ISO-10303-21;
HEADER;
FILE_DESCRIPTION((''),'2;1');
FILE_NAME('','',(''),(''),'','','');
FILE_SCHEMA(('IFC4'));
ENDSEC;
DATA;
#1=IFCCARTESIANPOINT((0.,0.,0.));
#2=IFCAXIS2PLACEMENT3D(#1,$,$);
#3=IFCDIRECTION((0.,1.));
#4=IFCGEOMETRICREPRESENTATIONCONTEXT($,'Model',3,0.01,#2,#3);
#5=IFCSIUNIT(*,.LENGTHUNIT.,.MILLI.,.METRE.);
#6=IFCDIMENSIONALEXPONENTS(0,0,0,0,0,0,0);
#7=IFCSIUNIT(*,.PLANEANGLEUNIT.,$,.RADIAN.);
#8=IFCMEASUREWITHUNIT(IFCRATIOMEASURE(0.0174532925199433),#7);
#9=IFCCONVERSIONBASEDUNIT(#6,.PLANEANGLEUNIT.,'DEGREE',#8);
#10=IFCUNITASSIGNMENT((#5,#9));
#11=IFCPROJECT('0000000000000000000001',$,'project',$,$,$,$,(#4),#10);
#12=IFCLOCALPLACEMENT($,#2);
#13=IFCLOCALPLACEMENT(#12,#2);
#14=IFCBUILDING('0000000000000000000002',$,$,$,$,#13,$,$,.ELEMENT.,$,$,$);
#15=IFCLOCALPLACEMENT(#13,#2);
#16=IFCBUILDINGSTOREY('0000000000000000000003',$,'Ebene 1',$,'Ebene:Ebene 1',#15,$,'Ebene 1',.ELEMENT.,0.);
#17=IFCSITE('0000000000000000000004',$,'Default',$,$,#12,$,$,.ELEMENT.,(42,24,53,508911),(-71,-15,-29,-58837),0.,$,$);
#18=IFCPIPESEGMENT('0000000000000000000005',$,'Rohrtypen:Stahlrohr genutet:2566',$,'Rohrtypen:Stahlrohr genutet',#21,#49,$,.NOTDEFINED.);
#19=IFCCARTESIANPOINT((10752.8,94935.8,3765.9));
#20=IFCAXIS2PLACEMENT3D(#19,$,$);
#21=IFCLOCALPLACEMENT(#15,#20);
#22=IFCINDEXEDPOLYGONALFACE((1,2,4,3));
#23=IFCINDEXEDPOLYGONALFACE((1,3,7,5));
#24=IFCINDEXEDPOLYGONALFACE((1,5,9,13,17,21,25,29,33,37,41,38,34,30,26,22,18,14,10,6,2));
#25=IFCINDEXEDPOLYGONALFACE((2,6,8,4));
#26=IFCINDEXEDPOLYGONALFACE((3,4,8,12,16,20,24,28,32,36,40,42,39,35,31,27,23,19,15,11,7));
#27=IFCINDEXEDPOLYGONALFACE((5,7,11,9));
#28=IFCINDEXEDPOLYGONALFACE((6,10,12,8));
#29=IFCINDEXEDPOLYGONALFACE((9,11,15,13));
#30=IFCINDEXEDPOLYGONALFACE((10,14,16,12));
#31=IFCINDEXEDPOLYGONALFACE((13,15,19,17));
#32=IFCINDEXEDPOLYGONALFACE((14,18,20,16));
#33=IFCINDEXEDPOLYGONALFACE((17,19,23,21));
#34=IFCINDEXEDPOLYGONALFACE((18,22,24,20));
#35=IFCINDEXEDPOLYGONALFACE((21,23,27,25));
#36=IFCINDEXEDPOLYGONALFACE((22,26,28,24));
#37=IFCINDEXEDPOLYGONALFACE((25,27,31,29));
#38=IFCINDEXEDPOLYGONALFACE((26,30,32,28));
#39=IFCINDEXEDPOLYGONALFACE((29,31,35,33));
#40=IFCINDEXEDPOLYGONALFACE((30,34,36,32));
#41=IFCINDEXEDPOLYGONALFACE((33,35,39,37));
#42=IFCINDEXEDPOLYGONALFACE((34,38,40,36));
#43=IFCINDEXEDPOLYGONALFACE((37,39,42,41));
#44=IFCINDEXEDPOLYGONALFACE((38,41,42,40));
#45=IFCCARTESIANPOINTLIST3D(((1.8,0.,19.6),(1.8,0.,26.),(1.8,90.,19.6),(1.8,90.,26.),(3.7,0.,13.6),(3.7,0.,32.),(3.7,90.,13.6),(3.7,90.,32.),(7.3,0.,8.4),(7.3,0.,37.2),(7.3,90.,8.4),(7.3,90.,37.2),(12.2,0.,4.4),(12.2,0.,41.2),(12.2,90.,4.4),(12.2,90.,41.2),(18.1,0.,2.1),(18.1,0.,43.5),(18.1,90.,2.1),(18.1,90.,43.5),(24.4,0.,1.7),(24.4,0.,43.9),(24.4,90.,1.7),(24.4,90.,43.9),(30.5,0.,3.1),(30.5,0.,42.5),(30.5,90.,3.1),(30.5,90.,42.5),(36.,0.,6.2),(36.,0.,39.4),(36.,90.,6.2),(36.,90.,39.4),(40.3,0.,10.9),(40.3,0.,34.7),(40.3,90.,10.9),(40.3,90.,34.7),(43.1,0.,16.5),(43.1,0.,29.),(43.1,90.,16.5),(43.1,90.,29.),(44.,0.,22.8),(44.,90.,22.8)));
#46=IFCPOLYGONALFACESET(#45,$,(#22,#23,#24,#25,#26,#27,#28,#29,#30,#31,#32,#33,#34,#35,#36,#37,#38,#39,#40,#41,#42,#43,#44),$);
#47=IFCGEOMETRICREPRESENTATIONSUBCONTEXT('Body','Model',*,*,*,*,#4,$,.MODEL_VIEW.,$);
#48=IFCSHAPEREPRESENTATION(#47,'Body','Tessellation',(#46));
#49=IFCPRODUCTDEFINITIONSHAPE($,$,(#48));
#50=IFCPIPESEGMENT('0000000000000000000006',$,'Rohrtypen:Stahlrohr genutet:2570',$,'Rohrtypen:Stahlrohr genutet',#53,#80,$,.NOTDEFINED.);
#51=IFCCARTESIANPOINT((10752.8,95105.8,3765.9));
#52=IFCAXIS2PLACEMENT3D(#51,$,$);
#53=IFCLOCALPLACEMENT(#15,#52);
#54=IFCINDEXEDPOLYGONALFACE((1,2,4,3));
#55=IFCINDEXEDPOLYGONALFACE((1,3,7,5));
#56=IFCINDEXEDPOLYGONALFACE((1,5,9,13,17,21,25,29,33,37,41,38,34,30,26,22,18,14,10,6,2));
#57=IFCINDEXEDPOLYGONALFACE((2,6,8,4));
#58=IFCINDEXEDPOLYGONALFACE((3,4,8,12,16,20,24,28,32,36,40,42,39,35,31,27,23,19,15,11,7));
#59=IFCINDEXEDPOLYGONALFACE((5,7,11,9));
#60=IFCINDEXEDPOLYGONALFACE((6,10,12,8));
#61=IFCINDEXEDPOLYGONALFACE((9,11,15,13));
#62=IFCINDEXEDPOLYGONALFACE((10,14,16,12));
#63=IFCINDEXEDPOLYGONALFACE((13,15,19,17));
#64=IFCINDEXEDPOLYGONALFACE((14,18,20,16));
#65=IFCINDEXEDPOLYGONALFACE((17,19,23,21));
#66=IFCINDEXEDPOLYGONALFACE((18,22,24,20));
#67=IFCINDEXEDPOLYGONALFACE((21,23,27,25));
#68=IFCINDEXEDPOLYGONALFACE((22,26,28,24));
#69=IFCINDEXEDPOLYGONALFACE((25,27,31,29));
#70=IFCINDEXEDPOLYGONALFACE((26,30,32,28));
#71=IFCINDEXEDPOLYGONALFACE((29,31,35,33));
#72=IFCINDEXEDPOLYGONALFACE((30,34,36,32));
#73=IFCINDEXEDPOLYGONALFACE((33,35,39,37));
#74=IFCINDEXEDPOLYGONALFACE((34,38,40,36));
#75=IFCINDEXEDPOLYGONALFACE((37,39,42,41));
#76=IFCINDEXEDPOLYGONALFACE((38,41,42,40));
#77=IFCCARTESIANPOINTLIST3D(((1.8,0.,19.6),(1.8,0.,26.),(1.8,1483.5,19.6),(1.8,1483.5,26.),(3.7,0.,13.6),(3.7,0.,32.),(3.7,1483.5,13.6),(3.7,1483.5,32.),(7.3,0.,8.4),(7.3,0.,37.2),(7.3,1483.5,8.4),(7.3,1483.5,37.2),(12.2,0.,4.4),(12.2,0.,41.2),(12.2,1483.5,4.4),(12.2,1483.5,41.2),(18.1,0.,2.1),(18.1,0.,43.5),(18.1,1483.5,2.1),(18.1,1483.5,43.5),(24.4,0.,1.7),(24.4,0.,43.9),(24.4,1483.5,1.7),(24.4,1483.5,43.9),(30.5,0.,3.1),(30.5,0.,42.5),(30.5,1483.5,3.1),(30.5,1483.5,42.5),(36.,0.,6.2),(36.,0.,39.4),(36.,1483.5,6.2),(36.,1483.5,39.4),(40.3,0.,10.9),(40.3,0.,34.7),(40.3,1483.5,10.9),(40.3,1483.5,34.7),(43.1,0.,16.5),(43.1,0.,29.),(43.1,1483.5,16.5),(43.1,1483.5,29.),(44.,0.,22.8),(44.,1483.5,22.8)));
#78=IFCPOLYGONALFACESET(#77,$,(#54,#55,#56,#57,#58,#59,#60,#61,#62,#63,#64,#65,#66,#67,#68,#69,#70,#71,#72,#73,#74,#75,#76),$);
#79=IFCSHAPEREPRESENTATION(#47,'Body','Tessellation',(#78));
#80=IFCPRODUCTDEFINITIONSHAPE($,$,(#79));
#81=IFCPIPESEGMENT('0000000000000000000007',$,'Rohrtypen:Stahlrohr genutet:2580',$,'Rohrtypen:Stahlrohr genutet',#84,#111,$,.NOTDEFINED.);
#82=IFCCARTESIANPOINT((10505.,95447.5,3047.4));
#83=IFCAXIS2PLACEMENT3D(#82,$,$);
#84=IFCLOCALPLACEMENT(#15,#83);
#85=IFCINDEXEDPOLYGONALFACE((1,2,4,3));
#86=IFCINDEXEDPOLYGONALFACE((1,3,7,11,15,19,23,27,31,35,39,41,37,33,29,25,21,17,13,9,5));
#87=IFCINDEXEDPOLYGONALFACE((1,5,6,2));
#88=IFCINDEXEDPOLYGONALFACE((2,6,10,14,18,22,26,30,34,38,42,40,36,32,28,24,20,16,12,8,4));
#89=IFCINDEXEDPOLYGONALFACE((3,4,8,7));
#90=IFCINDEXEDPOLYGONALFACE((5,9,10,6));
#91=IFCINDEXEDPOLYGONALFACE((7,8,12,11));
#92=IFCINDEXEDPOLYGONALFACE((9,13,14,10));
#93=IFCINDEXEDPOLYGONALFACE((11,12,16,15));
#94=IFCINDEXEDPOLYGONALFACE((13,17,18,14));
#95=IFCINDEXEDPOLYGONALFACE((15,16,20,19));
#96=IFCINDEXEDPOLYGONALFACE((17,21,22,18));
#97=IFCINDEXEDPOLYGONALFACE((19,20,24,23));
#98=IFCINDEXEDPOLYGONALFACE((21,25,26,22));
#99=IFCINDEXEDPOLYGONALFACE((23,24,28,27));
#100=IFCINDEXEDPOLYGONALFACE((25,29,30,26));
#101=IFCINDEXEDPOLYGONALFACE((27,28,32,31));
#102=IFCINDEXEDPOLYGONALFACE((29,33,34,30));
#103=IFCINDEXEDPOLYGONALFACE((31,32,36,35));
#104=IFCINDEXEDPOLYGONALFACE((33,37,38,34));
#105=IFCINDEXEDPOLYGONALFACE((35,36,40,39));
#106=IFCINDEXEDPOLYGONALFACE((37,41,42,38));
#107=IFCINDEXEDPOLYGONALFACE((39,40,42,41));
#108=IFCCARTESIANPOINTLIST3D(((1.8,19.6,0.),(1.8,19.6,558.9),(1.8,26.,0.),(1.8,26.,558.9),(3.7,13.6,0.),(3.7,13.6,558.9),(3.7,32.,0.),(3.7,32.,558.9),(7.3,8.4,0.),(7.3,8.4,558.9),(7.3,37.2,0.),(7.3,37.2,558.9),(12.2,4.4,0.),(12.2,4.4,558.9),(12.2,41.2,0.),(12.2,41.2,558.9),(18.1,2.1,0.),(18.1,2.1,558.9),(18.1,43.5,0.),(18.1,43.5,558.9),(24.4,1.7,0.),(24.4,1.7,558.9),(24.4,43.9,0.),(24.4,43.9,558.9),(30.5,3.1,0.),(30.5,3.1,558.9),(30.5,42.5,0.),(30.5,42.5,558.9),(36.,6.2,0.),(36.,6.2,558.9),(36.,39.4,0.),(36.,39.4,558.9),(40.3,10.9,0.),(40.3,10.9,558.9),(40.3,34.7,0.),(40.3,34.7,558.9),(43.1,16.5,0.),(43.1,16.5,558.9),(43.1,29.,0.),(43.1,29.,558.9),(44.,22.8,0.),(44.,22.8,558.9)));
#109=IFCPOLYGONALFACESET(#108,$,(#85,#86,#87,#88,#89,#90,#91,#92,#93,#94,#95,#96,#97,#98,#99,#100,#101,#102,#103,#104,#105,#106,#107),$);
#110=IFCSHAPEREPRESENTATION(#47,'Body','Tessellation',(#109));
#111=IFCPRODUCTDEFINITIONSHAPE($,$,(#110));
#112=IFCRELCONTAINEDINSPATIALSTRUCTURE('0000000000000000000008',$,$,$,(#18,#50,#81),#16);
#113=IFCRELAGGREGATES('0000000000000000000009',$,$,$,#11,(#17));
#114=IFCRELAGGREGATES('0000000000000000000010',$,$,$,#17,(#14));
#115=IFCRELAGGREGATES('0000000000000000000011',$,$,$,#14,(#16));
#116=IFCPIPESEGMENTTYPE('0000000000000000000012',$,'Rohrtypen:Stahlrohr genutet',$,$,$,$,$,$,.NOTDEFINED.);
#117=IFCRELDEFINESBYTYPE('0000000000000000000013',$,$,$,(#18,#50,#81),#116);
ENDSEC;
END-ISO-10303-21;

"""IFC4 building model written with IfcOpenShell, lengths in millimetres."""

from ifc_helpers import new_model, entity, si_unit, converted_unit, direction, frame, frame_2d, origin, origin_2d_with_axis, place, context, subcontext, project, spatial, circle, extrude, type_object, element, save


model = new_model("IFC4")

# Units and contexts
model_context = context("Model", 3, precision=0.01, world=origin(), true_north=direction((0.0, 1.0)))
body_context = subcontext(model_context, "Body", "Model", "MODEL_VIEW")
ifc_project = project(units=[si_unit("LENGTHUNIT", "METRE", prefix="MILLI"), converted_unit("PLANEANGLEUNIT", "DEGREE", entity("IfcRatioMeasure", 0.0174532925199433), si_unit("PLANEANGLEUNIT", "RADIAN"), dimensions=[0, 0, 0, 0, 0, 0, 0])], contexts=[model_context])

# Site, building, storey
site_placement = place(None, origin())
site = spatial("IfcSite", under=ifc_project, at=site_placement, Name="Default", CompositionType="ELEMENT", RefLatitude=(42, 24, 53, 508911), RefLongitude=(-71, -15, -29, -58837), RefElevation=0.0)
building_placement = place(site_placement, origin())
building = spatial("IfcBuilding", under=site, at=building_placement, CompositionType="ELEMENT")
storey_placement = place(building_placement, origin())
storey = spatial("IfcBuildingStorey", under=building, at=storey_placement, Name="Ebene 1", ObjectType="Ebene:Ebene 1", LongName="Ebene 1", CompositionType="ELEMENT", Elevation=0.0)

# Pipe segments
pipe_segment_type = type_object("IfcPipeSegmentType", Name="Rohrtypen:Stahlrohr genutet", PredefinedType="NOTDEFINED")
pipe_segment_1_placement = place(storey_placement, frame((10752.8, 94935.8, 3765.9)))
element("IfcPipeSegment", 1, at=pipe_segment_1_placement, inside=storey, type_object=pipe_segment_type, Name="Rohrtypen:Stahlrohr genutet:2566", ObjectType="Rohrtypen:Stahlrohr genutet", PredefinedType="NOTDEFINED", context=body_context, shape_type="SweptSolid", body=[
    extrude(circle(Radius=21.2, at=frame_2d((0.0, 0.0), x_axis=(1.0, 0.0))), frame((22.8, 0.0, 22.8), z_axis=(0.0, 1.0, 0.0), x_axis=(1.0, 0.0, 0.0)), (0.0, 0.0, 1.0), 90.0),
])
pipe_segment_2_placement = place(storey_placement, frame((10752.8, 95105.8, 3765.9)))
element("IfcPipeSegment", 2, at=pipe_segment_2_placement, inside=storey, type_object=pipe_segment_type, Name="Rohrtypen:Stahlrohr genutet:2570", ObjectType="Rohrtypen:Stahlrohr genutet", PredefinedType="NOTDEFINED", context=body_context, shape_type="SweptSolid", body=[
    extrude(circle(Radius=21.2, at=frame_2d((0.0, 0.0), x_axis=(1.0, 0.0))), frame((22.8, 0.0, 22.8), z_axis=(0.0, 1.0, 0.0), x_axis=(1.0, 0.0, 0.0)), (0.0, 0.0, 1.0), 1483.5),
])
pipe_segment_3_placement = place(storey_placement, frame((10505.0, 95447.5, 3047.4)))
element("IfcPipeSegment", 3, at=pipe_segment_3_placement, inside=storey, type_object=pipe_segment_type, Name="Rohrtypen:Stahlrohr genutet:2580", ObjectType="Rohrtypen:Stahlrohr genutet", PredefinedType="NOTDEFINED", context=body_context, shape_type="SweptSolid", body=[
    extrude(circle(Radius=21.2, at=origin_2d_with_axis()), frame((22.8, 22.8, 0.0)), (0.0, 0.0, 1.0), 558.9),
])

save(model, "model.ifc")
